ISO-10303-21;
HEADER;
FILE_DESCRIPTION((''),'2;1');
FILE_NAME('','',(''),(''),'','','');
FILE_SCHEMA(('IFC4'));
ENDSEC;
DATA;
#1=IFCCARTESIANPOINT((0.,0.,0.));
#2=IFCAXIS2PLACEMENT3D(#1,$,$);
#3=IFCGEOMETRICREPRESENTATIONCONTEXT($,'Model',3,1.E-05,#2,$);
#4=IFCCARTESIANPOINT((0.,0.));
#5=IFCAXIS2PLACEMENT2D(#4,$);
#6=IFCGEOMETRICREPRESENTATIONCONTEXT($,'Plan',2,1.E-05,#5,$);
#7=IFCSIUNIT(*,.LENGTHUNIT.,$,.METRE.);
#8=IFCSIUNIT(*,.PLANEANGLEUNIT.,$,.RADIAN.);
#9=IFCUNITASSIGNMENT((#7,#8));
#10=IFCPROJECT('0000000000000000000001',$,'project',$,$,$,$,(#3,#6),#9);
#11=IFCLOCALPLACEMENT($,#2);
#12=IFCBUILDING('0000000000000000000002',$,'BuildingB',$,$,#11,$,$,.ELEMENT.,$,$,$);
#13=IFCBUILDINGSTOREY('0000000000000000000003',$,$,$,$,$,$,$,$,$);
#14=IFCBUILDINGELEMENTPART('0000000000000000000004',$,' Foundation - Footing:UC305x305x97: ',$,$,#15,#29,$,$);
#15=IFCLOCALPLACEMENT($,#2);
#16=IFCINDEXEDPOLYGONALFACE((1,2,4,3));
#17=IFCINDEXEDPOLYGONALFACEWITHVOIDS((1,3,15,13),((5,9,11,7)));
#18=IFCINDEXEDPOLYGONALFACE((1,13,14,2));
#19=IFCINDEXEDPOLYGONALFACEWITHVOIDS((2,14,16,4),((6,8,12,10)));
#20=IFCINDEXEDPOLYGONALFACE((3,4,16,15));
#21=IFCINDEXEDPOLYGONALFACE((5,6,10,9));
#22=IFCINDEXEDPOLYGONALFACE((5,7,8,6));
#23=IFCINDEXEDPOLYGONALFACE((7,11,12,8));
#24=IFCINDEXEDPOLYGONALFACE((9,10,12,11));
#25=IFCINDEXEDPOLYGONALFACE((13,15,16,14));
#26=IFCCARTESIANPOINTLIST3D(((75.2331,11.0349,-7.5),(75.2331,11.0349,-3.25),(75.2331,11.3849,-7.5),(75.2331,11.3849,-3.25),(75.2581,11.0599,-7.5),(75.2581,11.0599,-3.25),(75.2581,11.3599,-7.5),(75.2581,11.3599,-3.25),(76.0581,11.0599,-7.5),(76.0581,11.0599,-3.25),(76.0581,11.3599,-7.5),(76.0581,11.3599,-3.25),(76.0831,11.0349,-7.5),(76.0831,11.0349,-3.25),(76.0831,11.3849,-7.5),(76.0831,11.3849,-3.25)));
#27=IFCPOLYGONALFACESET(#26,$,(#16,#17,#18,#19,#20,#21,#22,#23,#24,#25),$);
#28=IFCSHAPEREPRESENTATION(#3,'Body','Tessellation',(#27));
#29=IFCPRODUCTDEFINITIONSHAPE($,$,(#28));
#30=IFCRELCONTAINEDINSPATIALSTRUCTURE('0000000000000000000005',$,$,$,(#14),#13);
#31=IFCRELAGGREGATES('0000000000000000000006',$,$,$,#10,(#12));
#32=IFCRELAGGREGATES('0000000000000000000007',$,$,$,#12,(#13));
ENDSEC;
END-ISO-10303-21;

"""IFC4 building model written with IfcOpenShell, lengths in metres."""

from ifc_helpers import new_model, si_unit, origin, origin_2d, place, context, project, spatial, polyline, outline, extrude, element, save


model = new_model("IFC4")

# Units and contexts
model_context = context("Model", 3, precision=1e-05, world=origin())
plan_context = context("Plan", 2, precision=1e-05, world=origin_2d())
ifc_project = project(units=[si_unit("LENGTHUNIT", "METRE"), si_unit("PLANEANGLEUNIT", "RADIAN")], contexts=[model_context, plan_context])

# Building, storey
building_placement = place(None, origin())
building = spatial("IfcBuilding", under=ifc_project, at=building_placement, Name="BuildingB", CompositionType="ELEMENT")
storey = spatial("IfcBuildingStorey", under=building)

# Building element part, opening
building_element_part_1 = element("IfcBuildingElementPart", 1, inside=storey, Name=" Foundation - Footing:UC305x305x97: ", context=model_context, shape_type="SweptSolid", body=[
    extrude(outline(polyline([(75.2331, 11.0349, -7.5), (76.0831, 11.0349, -7.5), (76.0831, 11.3849, -7.5), (75.2331, 11.3849, -7.5), (75.2331, 11.0349, -7.5)])), None, (0.0, 0.0, 1.0), 4.25),
])
element("IfcOpeningElement", 2, inside=storey, cuts=building_element_part_1, context=model_context, shape_type="SweptSolid", body=[
    extrude(outline(polyline([(75.2581, 11.0599, -7.5), (76.0581, 11.0599, -7.5), (76.0581, 11.3599, -7.5), (75.2581, 11.3599, -7.5), (75.2581, 11.0599, -7.5)])), None, (0.0, 0.0, 1.0), 4.25),
])

save(model, "model.ifc")
